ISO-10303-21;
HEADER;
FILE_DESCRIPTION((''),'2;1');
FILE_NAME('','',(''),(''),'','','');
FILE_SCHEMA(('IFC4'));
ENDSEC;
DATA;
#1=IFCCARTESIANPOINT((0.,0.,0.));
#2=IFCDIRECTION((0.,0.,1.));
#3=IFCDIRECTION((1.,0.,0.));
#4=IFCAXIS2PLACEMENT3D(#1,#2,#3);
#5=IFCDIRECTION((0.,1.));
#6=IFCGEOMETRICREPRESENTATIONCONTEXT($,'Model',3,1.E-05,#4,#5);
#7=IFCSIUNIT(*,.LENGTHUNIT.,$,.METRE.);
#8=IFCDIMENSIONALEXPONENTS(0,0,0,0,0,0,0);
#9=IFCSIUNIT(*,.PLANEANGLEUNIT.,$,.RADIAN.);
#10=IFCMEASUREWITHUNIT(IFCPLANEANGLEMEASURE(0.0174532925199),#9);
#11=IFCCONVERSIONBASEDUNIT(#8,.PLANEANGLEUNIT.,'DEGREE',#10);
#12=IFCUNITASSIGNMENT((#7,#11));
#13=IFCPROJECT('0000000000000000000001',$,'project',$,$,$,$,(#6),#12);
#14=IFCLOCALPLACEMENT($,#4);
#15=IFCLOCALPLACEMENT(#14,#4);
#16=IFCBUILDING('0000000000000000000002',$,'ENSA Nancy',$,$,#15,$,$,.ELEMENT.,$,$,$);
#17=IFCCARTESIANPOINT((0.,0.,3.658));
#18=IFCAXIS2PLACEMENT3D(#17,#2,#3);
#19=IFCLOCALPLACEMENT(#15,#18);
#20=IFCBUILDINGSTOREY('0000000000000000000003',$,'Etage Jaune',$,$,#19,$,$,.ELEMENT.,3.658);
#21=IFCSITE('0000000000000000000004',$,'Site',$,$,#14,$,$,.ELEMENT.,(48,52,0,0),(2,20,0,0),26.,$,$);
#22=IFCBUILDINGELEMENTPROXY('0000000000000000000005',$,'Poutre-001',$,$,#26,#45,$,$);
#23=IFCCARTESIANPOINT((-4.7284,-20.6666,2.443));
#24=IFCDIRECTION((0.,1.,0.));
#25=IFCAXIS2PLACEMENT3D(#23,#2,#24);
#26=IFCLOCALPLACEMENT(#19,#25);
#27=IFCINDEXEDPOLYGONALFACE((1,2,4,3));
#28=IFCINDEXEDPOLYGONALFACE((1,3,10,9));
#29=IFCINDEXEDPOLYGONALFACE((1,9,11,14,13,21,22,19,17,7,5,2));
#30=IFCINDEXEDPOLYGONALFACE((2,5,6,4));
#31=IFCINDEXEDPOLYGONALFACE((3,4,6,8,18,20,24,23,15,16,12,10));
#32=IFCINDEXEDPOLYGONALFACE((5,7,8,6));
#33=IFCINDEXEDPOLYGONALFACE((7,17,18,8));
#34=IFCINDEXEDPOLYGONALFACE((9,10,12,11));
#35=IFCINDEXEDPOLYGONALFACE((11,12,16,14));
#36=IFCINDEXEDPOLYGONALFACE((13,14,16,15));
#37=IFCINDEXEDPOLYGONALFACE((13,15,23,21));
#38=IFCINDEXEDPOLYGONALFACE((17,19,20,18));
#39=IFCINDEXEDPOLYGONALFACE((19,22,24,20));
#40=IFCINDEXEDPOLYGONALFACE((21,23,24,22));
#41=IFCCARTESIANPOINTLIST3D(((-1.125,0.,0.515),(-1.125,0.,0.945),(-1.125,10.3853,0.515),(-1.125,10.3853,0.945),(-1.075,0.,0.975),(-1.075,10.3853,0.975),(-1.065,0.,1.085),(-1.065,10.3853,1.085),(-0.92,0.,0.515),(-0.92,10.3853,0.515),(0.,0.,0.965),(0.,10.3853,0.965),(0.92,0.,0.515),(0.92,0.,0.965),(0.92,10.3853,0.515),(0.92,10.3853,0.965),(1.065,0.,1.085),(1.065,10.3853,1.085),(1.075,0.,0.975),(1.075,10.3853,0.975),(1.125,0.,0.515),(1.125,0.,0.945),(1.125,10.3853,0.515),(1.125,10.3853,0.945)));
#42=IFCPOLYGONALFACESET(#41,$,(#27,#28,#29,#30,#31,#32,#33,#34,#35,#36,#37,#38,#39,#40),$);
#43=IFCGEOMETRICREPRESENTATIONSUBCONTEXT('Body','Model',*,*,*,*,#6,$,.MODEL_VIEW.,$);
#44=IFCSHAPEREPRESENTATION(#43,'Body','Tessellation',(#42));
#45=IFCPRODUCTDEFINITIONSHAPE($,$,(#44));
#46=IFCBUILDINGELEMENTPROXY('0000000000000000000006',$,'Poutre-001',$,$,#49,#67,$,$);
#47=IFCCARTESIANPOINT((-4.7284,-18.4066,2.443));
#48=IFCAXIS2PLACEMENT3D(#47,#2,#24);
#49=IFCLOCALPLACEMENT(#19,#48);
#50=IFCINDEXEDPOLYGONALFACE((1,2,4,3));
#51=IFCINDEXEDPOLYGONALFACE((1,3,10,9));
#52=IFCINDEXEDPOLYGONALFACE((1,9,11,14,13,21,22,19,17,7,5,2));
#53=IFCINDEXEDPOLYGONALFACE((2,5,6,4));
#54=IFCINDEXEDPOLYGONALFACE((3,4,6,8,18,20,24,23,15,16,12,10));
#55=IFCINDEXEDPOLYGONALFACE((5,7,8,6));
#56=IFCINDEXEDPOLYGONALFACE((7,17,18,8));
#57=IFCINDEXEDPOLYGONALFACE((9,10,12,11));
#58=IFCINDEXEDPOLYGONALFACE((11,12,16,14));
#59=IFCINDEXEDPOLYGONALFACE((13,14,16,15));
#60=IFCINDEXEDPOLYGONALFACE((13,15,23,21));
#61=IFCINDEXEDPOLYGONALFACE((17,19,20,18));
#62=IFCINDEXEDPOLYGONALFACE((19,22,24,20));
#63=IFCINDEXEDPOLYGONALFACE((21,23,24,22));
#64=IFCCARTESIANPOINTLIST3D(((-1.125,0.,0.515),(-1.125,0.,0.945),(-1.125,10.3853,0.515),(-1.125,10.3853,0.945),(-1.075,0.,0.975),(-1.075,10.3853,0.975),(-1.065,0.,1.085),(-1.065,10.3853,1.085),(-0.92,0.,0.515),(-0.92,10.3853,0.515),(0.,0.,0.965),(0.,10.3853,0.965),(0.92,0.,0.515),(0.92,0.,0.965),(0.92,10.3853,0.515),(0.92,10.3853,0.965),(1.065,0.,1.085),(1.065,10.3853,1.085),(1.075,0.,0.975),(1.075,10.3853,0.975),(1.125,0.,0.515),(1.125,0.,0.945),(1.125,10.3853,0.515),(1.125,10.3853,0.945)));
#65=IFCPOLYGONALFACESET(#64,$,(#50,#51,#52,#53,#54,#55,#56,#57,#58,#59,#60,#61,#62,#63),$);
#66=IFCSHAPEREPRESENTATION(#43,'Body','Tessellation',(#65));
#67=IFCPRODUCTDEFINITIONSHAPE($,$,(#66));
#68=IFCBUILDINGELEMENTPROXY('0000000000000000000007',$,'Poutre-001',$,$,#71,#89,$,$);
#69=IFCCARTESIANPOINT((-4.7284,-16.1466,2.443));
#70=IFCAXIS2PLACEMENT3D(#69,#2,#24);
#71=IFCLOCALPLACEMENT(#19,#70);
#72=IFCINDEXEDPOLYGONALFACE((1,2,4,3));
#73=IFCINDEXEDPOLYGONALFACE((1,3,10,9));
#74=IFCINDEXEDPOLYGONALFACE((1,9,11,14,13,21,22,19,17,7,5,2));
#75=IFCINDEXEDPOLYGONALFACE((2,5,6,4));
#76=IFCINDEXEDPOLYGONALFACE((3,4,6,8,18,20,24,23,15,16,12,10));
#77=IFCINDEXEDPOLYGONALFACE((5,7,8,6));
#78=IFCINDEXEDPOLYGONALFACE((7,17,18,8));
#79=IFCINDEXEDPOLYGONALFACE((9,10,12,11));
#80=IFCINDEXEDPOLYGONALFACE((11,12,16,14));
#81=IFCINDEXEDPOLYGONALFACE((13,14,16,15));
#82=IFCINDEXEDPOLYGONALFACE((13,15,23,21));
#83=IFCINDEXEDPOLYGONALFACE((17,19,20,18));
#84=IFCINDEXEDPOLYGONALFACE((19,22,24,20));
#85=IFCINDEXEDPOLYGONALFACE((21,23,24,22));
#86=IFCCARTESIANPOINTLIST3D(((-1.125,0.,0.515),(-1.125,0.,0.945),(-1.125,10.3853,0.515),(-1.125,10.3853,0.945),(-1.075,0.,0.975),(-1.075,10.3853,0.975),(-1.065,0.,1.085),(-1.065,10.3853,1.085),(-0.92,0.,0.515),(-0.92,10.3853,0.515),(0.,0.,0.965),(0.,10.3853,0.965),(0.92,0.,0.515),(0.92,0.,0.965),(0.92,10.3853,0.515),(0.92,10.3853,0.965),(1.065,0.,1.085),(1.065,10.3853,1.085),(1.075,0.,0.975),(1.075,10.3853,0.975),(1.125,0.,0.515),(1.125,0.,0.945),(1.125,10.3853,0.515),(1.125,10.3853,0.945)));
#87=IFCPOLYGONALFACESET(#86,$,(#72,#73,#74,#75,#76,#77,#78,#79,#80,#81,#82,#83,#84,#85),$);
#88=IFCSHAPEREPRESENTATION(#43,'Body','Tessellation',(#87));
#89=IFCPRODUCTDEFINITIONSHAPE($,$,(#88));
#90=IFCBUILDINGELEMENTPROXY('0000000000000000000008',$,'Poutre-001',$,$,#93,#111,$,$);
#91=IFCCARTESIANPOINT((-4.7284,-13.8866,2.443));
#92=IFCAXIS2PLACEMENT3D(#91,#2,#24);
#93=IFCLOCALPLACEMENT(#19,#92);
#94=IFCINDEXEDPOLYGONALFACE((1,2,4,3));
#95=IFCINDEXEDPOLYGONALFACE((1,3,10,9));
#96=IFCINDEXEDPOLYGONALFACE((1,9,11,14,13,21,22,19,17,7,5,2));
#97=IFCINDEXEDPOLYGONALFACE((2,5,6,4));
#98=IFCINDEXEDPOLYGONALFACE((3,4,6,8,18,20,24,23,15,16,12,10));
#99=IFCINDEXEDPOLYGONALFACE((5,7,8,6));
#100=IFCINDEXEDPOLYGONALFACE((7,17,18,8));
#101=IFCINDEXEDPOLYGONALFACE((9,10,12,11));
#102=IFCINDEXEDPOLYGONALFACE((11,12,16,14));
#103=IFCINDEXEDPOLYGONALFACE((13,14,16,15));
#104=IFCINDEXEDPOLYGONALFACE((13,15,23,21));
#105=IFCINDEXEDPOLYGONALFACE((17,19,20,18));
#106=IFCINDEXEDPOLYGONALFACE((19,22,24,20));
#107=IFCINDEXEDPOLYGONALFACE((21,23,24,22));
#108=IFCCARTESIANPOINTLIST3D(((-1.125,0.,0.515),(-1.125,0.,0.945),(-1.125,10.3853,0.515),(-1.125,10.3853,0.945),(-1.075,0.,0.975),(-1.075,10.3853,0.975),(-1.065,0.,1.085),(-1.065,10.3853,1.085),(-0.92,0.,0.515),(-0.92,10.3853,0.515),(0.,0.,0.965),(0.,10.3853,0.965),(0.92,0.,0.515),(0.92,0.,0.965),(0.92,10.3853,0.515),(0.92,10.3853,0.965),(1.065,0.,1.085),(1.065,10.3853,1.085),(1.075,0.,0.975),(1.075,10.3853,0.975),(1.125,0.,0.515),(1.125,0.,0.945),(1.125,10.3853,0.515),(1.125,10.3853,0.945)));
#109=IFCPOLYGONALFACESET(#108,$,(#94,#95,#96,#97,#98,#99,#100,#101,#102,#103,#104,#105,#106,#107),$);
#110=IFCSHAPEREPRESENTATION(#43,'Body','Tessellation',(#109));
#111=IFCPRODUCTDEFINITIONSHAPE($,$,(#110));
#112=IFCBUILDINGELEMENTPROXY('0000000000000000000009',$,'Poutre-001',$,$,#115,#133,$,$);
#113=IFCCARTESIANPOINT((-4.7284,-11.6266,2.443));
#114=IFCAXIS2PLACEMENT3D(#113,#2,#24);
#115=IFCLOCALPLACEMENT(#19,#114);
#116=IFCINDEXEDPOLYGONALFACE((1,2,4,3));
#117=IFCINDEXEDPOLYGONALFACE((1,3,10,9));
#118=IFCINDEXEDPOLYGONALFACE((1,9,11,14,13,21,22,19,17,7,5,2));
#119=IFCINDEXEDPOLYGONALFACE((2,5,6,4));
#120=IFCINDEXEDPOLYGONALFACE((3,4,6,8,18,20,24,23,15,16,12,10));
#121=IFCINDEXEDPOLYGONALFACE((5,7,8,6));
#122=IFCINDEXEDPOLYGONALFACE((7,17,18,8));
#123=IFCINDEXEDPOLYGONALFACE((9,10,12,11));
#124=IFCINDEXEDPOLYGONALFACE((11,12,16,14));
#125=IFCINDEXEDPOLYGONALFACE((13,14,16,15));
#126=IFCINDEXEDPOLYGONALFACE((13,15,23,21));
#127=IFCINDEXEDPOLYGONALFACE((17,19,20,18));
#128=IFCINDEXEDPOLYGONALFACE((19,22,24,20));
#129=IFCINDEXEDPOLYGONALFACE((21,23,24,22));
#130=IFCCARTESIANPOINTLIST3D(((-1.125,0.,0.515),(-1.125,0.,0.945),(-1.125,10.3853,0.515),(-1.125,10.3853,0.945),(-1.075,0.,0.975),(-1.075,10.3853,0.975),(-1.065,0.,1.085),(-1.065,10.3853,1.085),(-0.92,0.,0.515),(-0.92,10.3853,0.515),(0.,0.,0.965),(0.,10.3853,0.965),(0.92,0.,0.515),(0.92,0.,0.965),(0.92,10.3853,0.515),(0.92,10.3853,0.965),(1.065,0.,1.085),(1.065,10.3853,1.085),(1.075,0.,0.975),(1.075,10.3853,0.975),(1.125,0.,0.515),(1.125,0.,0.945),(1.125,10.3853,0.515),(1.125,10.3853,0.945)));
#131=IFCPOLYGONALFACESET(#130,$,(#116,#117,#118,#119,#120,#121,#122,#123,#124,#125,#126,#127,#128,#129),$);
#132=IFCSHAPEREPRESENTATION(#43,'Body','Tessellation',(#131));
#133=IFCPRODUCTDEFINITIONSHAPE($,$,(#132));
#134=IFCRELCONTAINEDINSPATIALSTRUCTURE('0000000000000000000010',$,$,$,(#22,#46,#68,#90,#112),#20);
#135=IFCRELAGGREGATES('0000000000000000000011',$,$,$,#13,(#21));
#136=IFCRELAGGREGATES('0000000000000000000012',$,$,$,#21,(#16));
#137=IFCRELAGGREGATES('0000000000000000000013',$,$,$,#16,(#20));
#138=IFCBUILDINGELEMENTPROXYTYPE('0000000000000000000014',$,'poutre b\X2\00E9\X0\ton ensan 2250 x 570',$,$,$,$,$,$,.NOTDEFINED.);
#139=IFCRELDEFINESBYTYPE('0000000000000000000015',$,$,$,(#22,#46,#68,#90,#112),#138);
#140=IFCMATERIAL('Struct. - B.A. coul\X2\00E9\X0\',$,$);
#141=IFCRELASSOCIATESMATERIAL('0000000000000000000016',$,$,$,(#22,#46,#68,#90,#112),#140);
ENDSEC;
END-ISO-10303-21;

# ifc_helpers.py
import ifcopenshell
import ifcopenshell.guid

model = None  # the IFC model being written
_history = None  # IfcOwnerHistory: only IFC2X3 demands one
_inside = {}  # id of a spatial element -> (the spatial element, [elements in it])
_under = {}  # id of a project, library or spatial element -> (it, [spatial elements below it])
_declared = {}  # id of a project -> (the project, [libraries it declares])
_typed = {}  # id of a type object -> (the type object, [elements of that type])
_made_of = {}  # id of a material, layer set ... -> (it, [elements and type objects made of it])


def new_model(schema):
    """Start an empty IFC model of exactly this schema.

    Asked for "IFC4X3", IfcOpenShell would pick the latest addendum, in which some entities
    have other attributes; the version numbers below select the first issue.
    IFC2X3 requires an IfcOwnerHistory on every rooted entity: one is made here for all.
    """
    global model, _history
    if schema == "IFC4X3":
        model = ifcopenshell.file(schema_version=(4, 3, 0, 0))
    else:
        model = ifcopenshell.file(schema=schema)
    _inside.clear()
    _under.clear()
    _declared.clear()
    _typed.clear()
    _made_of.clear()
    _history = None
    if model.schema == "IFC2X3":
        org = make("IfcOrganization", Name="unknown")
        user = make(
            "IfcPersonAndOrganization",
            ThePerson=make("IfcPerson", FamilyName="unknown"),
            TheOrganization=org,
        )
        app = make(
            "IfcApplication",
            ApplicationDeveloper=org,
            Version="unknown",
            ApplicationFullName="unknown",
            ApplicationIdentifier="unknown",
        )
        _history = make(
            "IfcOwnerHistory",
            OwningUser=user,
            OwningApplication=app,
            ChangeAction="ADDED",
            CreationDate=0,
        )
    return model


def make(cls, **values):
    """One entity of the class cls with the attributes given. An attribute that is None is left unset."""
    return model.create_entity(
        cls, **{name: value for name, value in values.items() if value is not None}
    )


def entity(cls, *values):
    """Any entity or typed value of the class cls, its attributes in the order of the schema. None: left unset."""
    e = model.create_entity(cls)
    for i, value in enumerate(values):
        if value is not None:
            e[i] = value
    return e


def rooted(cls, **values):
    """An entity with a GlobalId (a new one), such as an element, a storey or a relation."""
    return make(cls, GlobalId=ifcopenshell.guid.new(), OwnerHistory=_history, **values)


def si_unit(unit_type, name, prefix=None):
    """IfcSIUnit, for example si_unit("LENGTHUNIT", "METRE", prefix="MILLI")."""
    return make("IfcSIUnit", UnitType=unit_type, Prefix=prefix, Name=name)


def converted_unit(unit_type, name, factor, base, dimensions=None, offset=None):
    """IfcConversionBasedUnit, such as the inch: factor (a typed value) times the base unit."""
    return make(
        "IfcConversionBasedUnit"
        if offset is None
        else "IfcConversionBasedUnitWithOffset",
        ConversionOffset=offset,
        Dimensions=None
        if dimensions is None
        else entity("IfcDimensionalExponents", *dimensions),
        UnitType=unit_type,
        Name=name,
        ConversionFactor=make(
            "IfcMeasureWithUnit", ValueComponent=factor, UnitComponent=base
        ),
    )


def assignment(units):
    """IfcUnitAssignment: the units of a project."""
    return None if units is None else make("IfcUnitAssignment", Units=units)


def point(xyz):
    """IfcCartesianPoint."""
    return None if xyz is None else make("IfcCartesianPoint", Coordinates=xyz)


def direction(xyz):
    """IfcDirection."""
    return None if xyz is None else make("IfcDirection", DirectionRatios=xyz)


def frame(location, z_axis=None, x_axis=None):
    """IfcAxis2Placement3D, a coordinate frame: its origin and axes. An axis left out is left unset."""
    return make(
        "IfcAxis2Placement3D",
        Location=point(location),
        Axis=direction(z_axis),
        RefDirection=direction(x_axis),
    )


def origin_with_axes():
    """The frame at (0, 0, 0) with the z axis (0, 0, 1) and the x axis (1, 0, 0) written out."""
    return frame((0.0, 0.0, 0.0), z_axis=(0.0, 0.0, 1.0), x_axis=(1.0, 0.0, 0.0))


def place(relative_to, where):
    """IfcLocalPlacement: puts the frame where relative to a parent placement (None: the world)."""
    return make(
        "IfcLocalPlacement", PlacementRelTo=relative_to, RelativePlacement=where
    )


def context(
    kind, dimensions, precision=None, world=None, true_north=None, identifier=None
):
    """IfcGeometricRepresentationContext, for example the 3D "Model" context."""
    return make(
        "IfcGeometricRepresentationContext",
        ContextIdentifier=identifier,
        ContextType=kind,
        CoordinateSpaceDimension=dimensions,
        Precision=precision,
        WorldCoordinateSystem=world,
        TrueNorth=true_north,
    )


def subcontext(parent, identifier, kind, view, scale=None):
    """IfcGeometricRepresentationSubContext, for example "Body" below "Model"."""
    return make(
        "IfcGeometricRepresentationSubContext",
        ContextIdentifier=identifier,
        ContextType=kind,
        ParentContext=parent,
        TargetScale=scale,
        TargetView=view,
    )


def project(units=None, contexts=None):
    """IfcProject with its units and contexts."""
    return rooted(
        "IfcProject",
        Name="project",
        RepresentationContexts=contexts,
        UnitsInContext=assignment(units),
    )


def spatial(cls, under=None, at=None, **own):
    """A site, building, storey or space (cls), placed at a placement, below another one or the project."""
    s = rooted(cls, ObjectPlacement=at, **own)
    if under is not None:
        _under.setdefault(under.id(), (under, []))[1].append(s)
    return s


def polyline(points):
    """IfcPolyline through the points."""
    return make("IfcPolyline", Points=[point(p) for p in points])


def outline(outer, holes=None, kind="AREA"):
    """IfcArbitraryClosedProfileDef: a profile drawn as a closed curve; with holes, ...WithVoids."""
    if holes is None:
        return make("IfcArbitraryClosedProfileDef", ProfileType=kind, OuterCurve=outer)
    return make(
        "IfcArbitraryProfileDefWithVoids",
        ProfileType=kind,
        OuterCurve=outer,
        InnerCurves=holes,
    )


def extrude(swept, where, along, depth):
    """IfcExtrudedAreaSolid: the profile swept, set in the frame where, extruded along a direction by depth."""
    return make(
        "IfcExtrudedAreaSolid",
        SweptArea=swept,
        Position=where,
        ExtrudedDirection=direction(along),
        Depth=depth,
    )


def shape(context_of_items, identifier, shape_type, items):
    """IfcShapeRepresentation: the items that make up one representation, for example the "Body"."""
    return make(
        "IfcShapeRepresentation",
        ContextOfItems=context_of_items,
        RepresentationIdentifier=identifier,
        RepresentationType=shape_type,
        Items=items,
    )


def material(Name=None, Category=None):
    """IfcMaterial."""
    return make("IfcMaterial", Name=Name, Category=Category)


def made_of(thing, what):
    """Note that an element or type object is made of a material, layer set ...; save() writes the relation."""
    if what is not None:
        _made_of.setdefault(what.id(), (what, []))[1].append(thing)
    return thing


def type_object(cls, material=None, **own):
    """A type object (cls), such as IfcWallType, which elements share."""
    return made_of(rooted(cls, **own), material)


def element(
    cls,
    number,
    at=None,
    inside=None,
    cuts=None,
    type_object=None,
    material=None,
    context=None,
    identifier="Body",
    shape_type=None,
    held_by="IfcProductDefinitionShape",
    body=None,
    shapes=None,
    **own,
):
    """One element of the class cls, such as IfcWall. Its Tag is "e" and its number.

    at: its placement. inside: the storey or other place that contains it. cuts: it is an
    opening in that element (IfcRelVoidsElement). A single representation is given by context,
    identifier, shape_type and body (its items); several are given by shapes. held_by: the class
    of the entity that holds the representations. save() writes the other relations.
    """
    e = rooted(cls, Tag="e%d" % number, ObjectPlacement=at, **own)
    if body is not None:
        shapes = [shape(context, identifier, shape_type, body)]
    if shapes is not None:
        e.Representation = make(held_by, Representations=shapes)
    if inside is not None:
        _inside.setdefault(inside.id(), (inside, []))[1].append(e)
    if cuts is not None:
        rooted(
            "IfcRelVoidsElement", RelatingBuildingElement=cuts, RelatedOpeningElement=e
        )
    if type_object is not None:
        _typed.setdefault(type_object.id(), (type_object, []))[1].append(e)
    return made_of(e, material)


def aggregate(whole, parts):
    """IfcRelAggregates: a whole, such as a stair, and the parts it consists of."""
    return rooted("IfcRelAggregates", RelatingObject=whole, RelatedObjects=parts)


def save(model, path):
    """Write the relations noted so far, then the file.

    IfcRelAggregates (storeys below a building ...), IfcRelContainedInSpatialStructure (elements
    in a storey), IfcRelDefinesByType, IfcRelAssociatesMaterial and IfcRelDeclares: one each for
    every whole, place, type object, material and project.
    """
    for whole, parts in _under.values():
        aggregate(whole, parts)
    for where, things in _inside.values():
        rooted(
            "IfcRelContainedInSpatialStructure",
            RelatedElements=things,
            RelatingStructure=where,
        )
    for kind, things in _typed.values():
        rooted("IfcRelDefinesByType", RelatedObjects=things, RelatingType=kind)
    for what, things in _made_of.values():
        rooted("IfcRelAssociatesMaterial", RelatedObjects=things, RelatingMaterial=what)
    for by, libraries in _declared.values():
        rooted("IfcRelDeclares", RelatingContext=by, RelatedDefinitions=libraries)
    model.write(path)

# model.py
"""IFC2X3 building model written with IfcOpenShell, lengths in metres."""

from ifc_helpers import new_model, entity, si_unit, converted_unit, direction, frame, origin_with_axes, place, context, subcontext, project, spatial, polyline, outline, extrude, material, type_object, element, save


model = new_model("IFC2X3")

# Units and contexts
model_context = context("Model", 3, precision=1e-05, world=origin_with_axes(), true_north=direction((0.0, 1.0)))
body_context = subcontext(model_context, "Body", "Model", "MODEL_VIEW")
ifc_project = project(units=[si_unit("LENGTHUNIT", "METRE"), converted_unit("PLANEANGLEUNIT", "DEGREE", entity("IfcPlaneAngleMeasure", 0.0174532925199), si_unit("PLANEANGLEUNIT", "RADIAN"), dimensions=[0, 0, 0, 0, 0, 0, 0])], contexts=[model_context])

# Site, building, storey
site_placement = place(None, origin_with_axes())
site = spatial("IfcSite", under=ifc_project, at=site_placement, Name="Site", CompositionType="ELEMENT", RefLatitude=(48, 52, 0, 0), RefLongitude=(2, 20, 0, 0), RefElevation=26.0)
building_placement = place(site_placement, origin_with_axes())
building = spatial("IfcBuilding", under=site, at=building_placement, Name="ENSA Nancy", CompositionType="ELEMENT")
storey_placement = place(building_placement, frame((0.0, 0.0, 3.658), z_axis=(0.0, 0.0, 1.0), x_axis=(1.0, 0.0, 0.0)))
storey = spatial("IfcBuildingStorey", under=building, at=storey_placement, Name="Etage Jaune", CompositionType="ELEMENT", Elevation=3.658)

# Building element proxies
ifc_material_1 = material(Name="Struct. - B.A. coulé")
building_element_proxy_type_1 = type_object("IfcBuildingElementProxyType", Name="poutre béton ensan 2250 x 570", PredefinedType="NOTDEFINED")
for number, where, z_axis, x_axis, name in (
    (1, (-4.7284, -20.6666, 2.443), (0.0, 0.0, 1.0), (0.0, 1.0, 0.0), "Poutre-001"),
    (2, (-4.7284, -18.4066, 2.443), (0.0, 0.0, 1.0), (0.0, 1.0, 0.0), "Poutre-001"),
    (3, (-4.7284, -16.1466, 2.443), (0.0, 0.0, 1.0), (0.0, 1.0, 0.0), "Poutre-001"),
    (4, (-4.7284, -13.8866, 2.443), (0.0, 0.0, 1.0), (0.0, 1.0, 0.0), "Poutre-001"),
    (5, (-4.7284, -11.6266, 2.443), (0.0, 0.0, 1.0), (0.0, 1.0, 0.0), "Poutre-001"),
):
    element("IfcBuildingElementProxy", number, at=place(storey_placement, frame(where, z_axis=z_axis, x_axis=x_axis)), inside=storey, type_object=building_element_proxy_type_1, material=ifc_material_1, Name=name, context=body_context, shape_type="SweptSolid", body=[
        extrude(outline(polyline([(-1.065, 1.085), (-1.075, 0.975), (-1.125, 0.945), (-1.125, 0.515), (-0.92, 0.515), (0.0, 0.965), (0.92, 0.965), (0.92, 0.515), (1.125, 0.515), (1.125, 0.945), (1.075, 0.975), (1.065, 1.085), (-1.065, 1.085)])), frame((0.0, 10.3853, 0.0), z_axis=(0.0, -1.0, 0.0), x_axis=(1.0, 0.0, 0.0)), (0.0, 0.0, 1.0), 10.3853),
    ])

save(model, "model.ifc")
